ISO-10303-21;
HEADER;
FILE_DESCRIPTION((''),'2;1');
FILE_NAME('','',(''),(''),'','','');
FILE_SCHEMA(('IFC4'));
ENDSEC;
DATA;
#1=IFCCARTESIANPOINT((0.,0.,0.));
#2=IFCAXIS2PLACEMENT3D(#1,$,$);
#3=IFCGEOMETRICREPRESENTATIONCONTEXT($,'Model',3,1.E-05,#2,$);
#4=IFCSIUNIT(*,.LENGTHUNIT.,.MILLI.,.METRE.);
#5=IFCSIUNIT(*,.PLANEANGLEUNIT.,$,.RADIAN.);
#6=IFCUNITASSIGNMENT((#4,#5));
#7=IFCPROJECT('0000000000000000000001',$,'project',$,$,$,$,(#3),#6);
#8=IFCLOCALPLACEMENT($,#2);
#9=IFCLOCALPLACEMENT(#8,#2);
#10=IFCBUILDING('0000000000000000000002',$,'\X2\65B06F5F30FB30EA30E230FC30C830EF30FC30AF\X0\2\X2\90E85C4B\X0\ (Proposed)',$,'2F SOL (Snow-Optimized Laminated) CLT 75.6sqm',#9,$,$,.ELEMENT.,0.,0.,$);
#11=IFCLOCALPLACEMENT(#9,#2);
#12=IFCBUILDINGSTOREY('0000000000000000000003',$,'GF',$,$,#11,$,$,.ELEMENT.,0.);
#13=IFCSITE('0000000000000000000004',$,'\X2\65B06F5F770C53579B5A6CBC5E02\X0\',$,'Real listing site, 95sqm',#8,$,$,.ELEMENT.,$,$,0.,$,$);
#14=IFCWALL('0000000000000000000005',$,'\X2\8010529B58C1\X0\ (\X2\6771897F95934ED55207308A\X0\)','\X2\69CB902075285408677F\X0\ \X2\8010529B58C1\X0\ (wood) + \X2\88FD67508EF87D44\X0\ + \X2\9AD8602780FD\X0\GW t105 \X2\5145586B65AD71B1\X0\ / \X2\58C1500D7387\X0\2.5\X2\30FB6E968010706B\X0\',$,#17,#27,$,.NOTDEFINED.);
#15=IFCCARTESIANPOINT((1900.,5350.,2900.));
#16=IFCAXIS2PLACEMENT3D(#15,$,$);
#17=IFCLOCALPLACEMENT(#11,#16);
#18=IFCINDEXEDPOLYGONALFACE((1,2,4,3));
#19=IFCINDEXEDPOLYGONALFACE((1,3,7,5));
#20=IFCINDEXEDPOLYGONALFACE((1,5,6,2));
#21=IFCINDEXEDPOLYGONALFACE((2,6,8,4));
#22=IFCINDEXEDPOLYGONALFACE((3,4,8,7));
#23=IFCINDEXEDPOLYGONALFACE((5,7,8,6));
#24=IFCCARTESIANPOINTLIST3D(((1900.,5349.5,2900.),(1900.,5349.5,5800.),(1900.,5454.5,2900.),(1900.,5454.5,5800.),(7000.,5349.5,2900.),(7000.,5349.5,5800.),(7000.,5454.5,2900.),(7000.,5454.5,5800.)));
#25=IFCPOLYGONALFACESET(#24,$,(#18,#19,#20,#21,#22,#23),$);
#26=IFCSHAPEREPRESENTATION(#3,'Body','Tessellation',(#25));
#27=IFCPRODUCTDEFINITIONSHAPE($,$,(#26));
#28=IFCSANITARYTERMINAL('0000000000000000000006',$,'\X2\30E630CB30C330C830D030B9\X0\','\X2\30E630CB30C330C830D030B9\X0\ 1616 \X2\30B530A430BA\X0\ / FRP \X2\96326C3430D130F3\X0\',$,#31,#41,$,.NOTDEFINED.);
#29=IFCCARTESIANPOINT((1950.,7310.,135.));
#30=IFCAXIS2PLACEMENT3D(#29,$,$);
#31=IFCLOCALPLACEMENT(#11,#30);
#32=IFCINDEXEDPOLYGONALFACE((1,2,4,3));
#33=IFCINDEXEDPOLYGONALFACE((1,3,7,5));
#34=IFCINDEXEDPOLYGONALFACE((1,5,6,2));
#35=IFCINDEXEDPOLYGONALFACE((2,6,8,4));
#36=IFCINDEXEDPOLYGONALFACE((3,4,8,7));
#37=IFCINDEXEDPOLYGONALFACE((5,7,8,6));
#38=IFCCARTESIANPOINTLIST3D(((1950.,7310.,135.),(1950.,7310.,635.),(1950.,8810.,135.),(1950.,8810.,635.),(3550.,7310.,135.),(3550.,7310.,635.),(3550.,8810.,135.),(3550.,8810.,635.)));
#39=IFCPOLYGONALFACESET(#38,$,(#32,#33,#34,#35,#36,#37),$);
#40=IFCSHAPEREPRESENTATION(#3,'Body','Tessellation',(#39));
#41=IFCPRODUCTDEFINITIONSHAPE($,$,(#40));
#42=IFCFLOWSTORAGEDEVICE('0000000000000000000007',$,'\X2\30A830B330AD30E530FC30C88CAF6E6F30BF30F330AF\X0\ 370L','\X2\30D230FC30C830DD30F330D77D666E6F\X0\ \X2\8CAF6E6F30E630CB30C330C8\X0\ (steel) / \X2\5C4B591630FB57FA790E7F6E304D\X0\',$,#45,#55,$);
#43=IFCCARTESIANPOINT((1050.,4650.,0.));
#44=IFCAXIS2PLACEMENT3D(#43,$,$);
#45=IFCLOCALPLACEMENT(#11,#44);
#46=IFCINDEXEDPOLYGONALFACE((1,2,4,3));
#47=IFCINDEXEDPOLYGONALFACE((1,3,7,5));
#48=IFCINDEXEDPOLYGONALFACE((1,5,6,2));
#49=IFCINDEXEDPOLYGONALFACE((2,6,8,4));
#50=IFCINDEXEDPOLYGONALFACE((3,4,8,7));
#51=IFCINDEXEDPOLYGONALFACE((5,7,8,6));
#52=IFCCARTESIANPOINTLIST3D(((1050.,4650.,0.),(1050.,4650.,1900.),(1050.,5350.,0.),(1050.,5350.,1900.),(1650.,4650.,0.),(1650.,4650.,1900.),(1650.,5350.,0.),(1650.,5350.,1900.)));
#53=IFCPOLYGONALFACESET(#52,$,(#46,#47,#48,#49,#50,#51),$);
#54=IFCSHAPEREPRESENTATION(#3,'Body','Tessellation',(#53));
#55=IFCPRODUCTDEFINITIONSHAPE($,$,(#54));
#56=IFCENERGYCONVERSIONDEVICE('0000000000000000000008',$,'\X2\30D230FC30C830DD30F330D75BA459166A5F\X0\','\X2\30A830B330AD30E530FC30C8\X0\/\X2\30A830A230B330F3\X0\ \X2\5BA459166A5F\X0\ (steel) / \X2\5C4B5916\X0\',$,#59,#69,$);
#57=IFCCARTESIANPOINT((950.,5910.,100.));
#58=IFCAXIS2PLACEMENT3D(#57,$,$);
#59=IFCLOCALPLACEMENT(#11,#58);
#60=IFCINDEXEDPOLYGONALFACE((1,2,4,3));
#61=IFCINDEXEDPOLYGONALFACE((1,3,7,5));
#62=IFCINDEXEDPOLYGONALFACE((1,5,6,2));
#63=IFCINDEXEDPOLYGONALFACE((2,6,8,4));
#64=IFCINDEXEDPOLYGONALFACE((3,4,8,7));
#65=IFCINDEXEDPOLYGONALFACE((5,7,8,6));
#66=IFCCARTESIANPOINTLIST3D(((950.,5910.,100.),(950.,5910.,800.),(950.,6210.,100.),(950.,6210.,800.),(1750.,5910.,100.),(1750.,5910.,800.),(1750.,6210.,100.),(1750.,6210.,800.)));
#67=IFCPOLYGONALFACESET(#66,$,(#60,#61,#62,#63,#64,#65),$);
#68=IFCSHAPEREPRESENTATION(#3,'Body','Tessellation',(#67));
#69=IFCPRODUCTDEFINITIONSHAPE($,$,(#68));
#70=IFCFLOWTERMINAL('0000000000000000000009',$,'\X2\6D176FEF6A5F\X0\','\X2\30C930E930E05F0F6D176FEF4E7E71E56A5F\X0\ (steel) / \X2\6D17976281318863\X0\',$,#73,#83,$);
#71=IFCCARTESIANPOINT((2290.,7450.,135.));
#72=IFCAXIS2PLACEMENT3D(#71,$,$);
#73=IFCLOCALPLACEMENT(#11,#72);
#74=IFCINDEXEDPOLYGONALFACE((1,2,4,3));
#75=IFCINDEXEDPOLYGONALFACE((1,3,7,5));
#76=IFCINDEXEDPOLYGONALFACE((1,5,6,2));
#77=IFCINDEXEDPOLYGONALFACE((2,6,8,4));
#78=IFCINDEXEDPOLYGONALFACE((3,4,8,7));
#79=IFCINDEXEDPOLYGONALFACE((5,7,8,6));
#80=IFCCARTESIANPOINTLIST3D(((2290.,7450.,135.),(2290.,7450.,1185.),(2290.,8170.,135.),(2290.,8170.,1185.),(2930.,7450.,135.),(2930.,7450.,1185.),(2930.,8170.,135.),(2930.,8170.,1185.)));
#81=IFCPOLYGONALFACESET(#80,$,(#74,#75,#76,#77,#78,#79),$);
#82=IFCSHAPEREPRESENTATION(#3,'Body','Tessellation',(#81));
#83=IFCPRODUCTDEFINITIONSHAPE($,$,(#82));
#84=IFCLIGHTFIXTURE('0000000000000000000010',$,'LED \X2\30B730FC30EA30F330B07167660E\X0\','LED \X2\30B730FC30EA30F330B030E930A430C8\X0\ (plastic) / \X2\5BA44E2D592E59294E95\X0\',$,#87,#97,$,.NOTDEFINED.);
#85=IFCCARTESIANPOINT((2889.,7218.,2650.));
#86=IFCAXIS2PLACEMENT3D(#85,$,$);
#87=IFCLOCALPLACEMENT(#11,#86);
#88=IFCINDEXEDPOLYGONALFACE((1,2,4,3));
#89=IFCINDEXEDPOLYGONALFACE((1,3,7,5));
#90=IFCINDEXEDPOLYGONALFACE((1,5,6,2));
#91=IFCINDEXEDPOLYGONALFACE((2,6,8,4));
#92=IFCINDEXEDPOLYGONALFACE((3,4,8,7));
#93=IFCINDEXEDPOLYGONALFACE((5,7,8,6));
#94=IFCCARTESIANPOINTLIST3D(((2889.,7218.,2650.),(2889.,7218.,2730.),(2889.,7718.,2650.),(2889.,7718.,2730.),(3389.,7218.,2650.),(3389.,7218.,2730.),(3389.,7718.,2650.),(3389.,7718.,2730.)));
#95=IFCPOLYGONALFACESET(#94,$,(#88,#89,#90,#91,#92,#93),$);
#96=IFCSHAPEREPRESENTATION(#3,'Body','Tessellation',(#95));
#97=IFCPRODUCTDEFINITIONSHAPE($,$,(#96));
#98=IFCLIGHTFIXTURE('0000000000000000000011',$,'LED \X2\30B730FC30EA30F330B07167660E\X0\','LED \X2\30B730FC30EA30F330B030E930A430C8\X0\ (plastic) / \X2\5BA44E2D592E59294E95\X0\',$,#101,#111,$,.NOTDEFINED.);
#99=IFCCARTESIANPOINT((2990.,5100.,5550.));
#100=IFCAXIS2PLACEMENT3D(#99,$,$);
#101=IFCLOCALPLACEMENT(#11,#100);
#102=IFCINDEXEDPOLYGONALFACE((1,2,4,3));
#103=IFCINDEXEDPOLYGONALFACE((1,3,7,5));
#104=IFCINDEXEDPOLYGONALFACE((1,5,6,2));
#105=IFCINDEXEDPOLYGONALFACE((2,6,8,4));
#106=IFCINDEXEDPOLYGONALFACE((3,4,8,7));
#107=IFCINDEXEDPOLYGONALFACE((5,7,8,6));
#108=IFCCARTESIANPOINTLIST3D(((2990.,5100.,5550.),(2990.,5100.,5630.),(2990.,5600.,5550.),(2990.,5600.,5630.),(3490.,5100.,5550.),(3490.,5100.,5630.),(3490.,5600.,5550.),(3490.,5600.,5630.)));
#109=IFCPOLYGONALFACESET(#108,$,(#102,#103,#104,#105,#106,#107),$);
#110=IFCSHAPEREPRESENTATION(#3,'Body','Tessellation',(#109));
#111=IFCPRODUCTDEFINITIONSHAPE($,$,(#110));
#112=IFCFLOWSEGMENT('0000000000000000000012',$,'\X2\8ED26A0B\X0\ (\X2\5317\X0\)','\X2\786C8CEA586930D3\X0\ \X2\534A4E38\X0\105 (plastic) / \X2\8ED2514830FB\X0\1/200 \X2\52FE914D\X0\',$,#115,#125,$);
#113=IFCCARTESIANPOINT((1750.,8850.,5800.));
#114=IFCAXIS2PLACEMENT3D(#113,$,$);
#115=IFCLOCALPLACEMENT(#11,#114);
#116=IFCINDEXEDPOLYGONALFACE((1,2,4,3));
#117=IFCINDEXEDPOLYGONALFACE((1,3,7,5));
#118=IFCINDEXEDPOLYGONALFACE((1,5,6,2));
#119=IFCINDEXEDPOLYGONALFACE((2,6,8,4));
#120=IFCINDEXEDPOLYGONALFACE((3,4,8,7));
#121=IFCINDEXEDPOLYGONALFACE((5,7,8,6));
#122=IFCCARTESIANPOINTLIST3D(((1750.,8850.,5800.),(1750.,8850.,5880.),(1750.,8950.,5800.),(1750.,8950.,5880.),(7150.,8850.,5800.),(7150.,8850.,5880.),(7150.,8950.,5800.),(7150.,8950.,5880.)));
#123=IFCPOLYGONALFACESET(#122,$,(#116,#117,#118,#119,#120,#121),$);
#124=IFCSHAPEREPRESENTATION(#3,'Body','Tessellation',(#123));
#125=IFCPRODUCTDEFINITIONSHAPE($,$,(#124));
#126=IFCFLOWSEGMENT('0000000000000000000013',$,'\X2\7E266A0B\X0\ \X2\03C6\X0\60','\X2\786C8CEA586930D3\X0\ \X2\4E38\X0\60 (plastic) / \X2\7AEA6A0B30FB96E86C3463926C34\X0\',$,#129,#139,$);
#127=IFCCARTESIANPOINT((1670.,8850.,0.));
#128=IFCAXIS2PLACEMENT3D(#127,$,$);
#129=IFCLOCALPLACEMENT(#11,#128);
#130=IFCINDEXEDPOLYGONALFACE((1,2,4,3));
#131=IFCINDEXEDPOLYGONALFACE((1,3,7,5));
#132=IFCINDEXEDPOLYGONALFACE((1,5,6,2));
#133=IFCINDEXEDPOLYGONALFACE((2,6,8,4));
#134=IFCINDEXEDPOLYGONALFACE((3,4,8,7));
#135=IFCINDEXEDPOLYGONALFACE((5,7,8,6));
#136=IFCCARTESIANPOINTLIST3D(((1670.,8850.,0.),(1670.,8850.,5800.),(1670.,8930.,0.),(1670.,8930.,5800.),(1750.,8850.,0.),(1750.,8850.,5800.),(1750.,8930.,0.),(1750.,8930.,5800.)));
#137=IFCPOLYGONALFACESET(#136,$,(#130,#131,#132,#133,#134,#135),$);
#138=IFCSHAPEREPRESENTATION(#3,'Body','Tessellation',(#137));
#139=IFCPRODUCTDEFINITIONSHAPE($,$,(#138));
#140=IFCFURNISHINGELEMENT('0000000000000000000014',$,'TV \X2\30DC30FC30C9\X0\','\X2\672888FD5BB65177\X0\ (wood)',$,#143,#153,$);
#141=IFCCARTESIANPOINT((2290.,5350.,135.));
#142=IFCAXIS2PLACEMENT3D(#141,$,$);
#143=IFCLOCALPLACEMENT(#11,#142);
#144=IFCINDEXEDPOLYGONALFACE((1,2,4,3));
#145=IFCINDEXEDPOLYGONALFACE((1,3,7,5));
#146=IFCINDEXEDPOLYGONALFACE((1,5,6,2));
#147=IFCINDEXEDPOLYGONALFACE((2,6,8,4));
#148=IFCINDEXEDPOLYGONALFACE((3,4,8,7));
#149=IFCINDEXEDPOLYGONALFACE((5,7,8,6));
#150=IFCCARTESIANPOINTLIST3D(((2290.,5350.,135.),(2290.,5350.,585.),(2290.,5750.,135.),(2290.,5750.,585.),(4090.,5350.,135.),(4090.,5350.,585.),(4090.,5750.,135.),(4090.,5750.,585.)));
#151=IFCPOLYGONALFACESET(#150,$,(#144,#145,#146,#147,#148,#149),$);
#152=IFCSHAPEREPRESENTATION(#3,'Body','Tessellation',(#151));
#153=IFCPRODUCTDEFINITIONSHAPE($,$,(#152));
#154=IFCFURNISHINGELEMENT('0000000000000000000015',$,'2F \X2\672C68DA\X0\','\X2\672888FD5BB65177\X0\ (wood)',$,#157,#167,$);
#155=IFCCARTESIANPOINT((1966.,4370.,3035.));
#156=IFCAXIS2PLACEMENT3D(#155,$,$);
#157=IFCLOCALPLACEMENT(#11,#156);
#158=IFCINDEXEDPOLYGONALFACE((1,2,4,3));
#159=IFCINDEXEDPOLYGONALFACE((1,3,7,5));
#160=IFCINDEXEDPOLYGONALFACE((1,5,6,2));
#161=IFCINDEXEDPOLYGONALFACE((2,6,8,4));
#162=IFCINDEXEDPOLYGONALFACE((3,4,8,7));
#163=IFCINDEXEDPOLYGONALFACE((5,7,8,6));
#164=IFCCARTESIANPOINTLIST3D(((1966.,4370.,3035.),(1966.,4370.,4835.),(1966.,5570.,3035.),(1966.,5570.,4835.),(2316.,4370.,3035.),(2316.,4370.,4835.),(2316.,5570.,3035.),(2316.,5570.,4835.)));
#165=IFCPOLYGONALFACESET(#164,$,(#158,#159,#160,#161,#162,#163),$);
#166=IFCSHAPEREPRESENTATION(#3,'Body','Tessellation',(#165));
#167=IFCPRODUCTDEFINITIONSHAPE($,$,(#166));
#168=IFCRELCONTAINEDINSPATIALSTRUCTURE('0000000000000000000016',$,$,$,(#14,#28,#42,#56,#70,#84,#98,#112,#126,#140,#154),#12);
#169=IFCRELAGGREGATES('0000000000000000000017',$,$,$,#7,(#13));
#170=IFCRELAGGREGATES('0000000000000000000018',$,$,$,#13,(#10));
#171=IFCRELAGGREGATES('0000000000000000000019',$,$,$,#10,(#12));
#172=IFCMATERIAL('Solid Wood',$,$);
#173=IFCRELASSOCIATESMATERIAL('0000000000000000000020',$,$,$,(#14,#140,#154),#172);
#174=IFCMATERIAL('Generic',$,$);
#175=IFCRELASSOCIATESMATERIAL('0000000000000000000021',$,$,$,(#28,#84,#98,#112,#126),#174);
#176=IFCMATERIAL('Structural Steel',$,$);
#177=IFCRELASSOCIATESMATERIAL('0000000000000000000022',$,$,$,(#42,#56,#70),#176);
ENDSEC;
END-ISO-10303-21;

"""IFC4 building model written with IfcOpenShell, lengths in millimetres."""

from ifc_helpers import new_model, si_unit, frame, frame_2d, origin, place, context, project, spatial, rectangle, extrude, material, element, save


model = new_model("IFC4")

# Units and contexts
model_context = context("Model", 3, precision=1e-05, world=origin())
ifc_project = project(units=[si_unit("LENGTHUNIT", "METRE", prefix="MILLI"), si_unit("PLANEANGLEUNIT", "RADIAN")], contexts=[model_context])

# Site, building, storey
site_placement = place(None, origin())
site = spatial("IfcSite", under=ifc_project, at=site_placement, Name="新潟県南魚沼市", ObjectType="Real listing site, 95sqm", CompositionType="ELEMENT", RefElevation=0.0)
building_placement = place(site_placement, origin())
building = spatial("IfcBuilding", under=site, at=building_placement, Name="新潟・リモートワーク2部屋 (Proposed)", ObjectType="2F SOL (Snow-Optimized Laminated) CLT 75.6sqm", CompositionType="ELEMENT", ElevationOfRefHeight=0.0, ElevationOfTerrain=0.0)
storey_placement = place(building_placement, origin())
storey = spatial("IfcBuildingStorey", under=building, at=storey_placement, Name="GF", CompositionType="ELEMENT", Elevation=0.0)

# Shared definitions
ifc_material_1 = material(Name="Solid Wood")

# Wall
wall_1_placement = place(storey_placement, frame((1900.0, 5350.0, 2900.0)))
element("IfcWall", 1, at=wall_1_placement, inside=storey, material=ifc_material_1, Name="耐力壁 (東西間仕切り)", Description="構造用合板 耐力壁 (wood) + 製材軸組 + 高性能GW t105 充填断熱 / 壁倍率2.5・準耐火", PredefinedType="NOTDEFINED", context=model_context, shape_type="SweptSolid", body=[
    extrude(rectangle(XDim=5100.0, YDim=105.0, at=frame_2d((2550.0, 52.0))), frame((1900.0, 5350.0, 2900.0)), (0.0, 0.0, 1.0), 2900.0),
])

# Sanitary terminal
ifc_material_2 = material(Name="Generic")
sanitary_terminal_placement = place(storey_placement, frame((1950.0, 7310.0, 135.0)))
element("IfcSanitaryTerminal", 2, at=sanitary_terminal_placement, inside=storey, material=ifc_material_2, Name="ユニットバス", Description="ユニットバス 1616 サイズ / FRP 防水パン", PredefinedType="NOTDEFINED", context=model_context, shape_type="SweptSolid", body=[
    extrude(rectangle(XDim=1600.0, YDim=1500.0, at=frame_2d((800.0, 750.0))), frame((1950.0, 7310.0, 135.0)), (0.0, 0.0, 1.0), 500.0),
])

# Flow storage device
ifc_material_3 = material(Name="Structural Steel")
flow_storage_device_placement = place(storey_placement, frame((1050.0, 4650.0, 0.0)))
element("IfcFlowStorageDevice", 3, at=flow_storage_device_placement, inside=storey, material=ifc_material_3, Name="エコキュート貯湯タンク 370L", Description="ヒートポンプ給湯 貯湯ユニット (steel) / 屋外・基礎置き", context=model_context, shape_type="SweptSolid", body=[
    extrude(rectangle(XDim=600.0, YDim=700.0, at=frame_2d((300.0, 350.0))), frame((1050.0, 4650.0, 0.0)), (0.0, 0.0, 1.0), 1900.0),
])

# Energy conversion device
energy_conversion_device_placement = place(storey_placement, frame((950.0, 5910.0, 100.0)))
element("IfcEnergyConversionDevice", 4, at=energy_conversion_device_placement, inside=storey, material=ifc_material_3, Name="ヒートポンプ室外機", Description="エコキュート/エアコン 室外機 (steel) / 屋外", context=model_context, shape_type="SweptSolid", body=[
    extrude(rectangle(XDim=800.0, YDim=300.0, at=frame_2d((400.0, 150.0))), frame((950.0, 5910.0, 100.0)), (0.0, 0.0, 1.0), 700.0),
])

# Flow terminal
flow_terminal_placement = place(storey_placement, frame((2290.0, 7450.0, 135.0)))
element("IfcFlowTerminal", 5, at=flow_terminal_placement, inside=storey, material=ifc_material_3, Name="洗濯機", Description="ドラム式洗濯乾燥機 (steel) / 洗面脱衣", context=model_context, shape_type="SweptSolid", body=[
    extrude(rectangle(XDim=640.0, YDim=720.0, at=frame_2d((320.0, 360.0))), frame((2290.0, 7450.0, 135.0)), (0.0, 0.0, 1.0), 1050.0),
])

# Light fixtures
light_fixture_1_placement = place(storey_placement, frame((2889.0, 7218.0, 2650.0)))
element("IfcLightFixture", 6, at=light_fixture_1_placement, inside=storey, material=ifc_material_2, Name="LED シーリング照明", Description="LED シーリングライト (plastic) / 室中央天井", PredefinedType="NOTDEFINED", context=model_context, shape_type="SweptSolid", body=[
    extrude(rectangle(XDim=500.0, YDim=500.0, at=frame_2d((250.0, 250.0))), frame((2889.0, 7218.0, 2650.0)), (0.0, 0.0, 1.0), 80.0),
])
light_fixture_2_placement = place(storey_placement, frame((2990.0, 5100.0, 5550.0)))
element("IfcLightFixture", 7, at=light_fixture_2_placement, inside=storey, material=ifc_material_2, Name="LED シーリング照明", Description="LED シーリングライト (plastic) / 室中央天井", PredefinedType="NOTDEFINED", context=model_context, shape_type="SweptSolid", body=[
    extrude(rectangle(XDim=500.0, YDim=500.0, at=frame_2d((250.0, 250.0))), frame((2990.0, 5100.0, 5550.0)), (0.0, 0.0, 1.0), 80.0),
])

# Flow segments
flow_segment_1_placement = place(storey_placement, frame((1750.0, 8850.0, 5800.0)))
element("IfcFlowSegment", 8, at=flow_segment_1_placement, inside=storey, material=ifc_material_2, Name="軒樋 (北)", Description="硬質塩ビ 半丸105 (plastic) / 軒先・1/200 勾配", context=model_context, shape_type="SweptSolid", body=[
    extrude(rectangle(XDim=5400.0, YDim=100.0, at=frame_2d((2700.0, 50.0))), frame((1750.0, 8850.0, 5800.0)), (0.0, 0.0, 1.0), 80.0),
])
flow_segment_2_placement = place(storey_placement, frame((1670.0, 8850.0, 0.0)))
element("IfcFlowSegment", 9, at=flow_segment_2_placement, inside=storey, material=ifc_material_2, Name="縦樋 φ60", Description="硬質塩ビ 丸60 (plastic) / 竪樋・雨水排水", context=model_context, shape_type="SweptSolid", body=[
    extrude(rectangle(XDim=80.0, YDim=80.0, at=frame_2d((40.0, 40.0))), frame((1670.0, 8850.0, 0.0)), (0.0, 0.0, 1.0), 5800.0),
])

# Furnishing elements
furnishing_1_placement = place(storey_placement, frame((2290.0, 5350.0, 135.0)))
element("IfcFurnishingElement", 10, at=furnishing_1_placement, inside=storey, material=ifc_material_1, Name="TV ボード", Description="木製家具 (wood)", context=model_context, shape_type="SweptSolid", body=[
    extrude(rectangle(XDim=1800.0, YDim=400.0, at=frame_2d((900.0, 200.0))), frame((2290.0, 5350.0, 135.0)), (0.0, 0.0, 1.0), 450.0),
])
furnishing_2_placement = place(storey_placement, frame((1966.0, 4370.0, 3035.0)))
element("IfcFurnishingElement", 11, at=furnishing_2_placement, inside=storey, material=ifc_material_1, Name="2F 本棚", Description="木製家具 (wood)", context=model_context, shape_type="SweptSolid", body=[
    extrude(rectangle(XDim=350.0, YDim=1200.0, at=frame_2d((175.0, 600.0))), frame((1966.0, 4370.0, 3035.0)), (0.0, 0.0, 1.0), 1800.0),
])

save(model, "model.ifc")
